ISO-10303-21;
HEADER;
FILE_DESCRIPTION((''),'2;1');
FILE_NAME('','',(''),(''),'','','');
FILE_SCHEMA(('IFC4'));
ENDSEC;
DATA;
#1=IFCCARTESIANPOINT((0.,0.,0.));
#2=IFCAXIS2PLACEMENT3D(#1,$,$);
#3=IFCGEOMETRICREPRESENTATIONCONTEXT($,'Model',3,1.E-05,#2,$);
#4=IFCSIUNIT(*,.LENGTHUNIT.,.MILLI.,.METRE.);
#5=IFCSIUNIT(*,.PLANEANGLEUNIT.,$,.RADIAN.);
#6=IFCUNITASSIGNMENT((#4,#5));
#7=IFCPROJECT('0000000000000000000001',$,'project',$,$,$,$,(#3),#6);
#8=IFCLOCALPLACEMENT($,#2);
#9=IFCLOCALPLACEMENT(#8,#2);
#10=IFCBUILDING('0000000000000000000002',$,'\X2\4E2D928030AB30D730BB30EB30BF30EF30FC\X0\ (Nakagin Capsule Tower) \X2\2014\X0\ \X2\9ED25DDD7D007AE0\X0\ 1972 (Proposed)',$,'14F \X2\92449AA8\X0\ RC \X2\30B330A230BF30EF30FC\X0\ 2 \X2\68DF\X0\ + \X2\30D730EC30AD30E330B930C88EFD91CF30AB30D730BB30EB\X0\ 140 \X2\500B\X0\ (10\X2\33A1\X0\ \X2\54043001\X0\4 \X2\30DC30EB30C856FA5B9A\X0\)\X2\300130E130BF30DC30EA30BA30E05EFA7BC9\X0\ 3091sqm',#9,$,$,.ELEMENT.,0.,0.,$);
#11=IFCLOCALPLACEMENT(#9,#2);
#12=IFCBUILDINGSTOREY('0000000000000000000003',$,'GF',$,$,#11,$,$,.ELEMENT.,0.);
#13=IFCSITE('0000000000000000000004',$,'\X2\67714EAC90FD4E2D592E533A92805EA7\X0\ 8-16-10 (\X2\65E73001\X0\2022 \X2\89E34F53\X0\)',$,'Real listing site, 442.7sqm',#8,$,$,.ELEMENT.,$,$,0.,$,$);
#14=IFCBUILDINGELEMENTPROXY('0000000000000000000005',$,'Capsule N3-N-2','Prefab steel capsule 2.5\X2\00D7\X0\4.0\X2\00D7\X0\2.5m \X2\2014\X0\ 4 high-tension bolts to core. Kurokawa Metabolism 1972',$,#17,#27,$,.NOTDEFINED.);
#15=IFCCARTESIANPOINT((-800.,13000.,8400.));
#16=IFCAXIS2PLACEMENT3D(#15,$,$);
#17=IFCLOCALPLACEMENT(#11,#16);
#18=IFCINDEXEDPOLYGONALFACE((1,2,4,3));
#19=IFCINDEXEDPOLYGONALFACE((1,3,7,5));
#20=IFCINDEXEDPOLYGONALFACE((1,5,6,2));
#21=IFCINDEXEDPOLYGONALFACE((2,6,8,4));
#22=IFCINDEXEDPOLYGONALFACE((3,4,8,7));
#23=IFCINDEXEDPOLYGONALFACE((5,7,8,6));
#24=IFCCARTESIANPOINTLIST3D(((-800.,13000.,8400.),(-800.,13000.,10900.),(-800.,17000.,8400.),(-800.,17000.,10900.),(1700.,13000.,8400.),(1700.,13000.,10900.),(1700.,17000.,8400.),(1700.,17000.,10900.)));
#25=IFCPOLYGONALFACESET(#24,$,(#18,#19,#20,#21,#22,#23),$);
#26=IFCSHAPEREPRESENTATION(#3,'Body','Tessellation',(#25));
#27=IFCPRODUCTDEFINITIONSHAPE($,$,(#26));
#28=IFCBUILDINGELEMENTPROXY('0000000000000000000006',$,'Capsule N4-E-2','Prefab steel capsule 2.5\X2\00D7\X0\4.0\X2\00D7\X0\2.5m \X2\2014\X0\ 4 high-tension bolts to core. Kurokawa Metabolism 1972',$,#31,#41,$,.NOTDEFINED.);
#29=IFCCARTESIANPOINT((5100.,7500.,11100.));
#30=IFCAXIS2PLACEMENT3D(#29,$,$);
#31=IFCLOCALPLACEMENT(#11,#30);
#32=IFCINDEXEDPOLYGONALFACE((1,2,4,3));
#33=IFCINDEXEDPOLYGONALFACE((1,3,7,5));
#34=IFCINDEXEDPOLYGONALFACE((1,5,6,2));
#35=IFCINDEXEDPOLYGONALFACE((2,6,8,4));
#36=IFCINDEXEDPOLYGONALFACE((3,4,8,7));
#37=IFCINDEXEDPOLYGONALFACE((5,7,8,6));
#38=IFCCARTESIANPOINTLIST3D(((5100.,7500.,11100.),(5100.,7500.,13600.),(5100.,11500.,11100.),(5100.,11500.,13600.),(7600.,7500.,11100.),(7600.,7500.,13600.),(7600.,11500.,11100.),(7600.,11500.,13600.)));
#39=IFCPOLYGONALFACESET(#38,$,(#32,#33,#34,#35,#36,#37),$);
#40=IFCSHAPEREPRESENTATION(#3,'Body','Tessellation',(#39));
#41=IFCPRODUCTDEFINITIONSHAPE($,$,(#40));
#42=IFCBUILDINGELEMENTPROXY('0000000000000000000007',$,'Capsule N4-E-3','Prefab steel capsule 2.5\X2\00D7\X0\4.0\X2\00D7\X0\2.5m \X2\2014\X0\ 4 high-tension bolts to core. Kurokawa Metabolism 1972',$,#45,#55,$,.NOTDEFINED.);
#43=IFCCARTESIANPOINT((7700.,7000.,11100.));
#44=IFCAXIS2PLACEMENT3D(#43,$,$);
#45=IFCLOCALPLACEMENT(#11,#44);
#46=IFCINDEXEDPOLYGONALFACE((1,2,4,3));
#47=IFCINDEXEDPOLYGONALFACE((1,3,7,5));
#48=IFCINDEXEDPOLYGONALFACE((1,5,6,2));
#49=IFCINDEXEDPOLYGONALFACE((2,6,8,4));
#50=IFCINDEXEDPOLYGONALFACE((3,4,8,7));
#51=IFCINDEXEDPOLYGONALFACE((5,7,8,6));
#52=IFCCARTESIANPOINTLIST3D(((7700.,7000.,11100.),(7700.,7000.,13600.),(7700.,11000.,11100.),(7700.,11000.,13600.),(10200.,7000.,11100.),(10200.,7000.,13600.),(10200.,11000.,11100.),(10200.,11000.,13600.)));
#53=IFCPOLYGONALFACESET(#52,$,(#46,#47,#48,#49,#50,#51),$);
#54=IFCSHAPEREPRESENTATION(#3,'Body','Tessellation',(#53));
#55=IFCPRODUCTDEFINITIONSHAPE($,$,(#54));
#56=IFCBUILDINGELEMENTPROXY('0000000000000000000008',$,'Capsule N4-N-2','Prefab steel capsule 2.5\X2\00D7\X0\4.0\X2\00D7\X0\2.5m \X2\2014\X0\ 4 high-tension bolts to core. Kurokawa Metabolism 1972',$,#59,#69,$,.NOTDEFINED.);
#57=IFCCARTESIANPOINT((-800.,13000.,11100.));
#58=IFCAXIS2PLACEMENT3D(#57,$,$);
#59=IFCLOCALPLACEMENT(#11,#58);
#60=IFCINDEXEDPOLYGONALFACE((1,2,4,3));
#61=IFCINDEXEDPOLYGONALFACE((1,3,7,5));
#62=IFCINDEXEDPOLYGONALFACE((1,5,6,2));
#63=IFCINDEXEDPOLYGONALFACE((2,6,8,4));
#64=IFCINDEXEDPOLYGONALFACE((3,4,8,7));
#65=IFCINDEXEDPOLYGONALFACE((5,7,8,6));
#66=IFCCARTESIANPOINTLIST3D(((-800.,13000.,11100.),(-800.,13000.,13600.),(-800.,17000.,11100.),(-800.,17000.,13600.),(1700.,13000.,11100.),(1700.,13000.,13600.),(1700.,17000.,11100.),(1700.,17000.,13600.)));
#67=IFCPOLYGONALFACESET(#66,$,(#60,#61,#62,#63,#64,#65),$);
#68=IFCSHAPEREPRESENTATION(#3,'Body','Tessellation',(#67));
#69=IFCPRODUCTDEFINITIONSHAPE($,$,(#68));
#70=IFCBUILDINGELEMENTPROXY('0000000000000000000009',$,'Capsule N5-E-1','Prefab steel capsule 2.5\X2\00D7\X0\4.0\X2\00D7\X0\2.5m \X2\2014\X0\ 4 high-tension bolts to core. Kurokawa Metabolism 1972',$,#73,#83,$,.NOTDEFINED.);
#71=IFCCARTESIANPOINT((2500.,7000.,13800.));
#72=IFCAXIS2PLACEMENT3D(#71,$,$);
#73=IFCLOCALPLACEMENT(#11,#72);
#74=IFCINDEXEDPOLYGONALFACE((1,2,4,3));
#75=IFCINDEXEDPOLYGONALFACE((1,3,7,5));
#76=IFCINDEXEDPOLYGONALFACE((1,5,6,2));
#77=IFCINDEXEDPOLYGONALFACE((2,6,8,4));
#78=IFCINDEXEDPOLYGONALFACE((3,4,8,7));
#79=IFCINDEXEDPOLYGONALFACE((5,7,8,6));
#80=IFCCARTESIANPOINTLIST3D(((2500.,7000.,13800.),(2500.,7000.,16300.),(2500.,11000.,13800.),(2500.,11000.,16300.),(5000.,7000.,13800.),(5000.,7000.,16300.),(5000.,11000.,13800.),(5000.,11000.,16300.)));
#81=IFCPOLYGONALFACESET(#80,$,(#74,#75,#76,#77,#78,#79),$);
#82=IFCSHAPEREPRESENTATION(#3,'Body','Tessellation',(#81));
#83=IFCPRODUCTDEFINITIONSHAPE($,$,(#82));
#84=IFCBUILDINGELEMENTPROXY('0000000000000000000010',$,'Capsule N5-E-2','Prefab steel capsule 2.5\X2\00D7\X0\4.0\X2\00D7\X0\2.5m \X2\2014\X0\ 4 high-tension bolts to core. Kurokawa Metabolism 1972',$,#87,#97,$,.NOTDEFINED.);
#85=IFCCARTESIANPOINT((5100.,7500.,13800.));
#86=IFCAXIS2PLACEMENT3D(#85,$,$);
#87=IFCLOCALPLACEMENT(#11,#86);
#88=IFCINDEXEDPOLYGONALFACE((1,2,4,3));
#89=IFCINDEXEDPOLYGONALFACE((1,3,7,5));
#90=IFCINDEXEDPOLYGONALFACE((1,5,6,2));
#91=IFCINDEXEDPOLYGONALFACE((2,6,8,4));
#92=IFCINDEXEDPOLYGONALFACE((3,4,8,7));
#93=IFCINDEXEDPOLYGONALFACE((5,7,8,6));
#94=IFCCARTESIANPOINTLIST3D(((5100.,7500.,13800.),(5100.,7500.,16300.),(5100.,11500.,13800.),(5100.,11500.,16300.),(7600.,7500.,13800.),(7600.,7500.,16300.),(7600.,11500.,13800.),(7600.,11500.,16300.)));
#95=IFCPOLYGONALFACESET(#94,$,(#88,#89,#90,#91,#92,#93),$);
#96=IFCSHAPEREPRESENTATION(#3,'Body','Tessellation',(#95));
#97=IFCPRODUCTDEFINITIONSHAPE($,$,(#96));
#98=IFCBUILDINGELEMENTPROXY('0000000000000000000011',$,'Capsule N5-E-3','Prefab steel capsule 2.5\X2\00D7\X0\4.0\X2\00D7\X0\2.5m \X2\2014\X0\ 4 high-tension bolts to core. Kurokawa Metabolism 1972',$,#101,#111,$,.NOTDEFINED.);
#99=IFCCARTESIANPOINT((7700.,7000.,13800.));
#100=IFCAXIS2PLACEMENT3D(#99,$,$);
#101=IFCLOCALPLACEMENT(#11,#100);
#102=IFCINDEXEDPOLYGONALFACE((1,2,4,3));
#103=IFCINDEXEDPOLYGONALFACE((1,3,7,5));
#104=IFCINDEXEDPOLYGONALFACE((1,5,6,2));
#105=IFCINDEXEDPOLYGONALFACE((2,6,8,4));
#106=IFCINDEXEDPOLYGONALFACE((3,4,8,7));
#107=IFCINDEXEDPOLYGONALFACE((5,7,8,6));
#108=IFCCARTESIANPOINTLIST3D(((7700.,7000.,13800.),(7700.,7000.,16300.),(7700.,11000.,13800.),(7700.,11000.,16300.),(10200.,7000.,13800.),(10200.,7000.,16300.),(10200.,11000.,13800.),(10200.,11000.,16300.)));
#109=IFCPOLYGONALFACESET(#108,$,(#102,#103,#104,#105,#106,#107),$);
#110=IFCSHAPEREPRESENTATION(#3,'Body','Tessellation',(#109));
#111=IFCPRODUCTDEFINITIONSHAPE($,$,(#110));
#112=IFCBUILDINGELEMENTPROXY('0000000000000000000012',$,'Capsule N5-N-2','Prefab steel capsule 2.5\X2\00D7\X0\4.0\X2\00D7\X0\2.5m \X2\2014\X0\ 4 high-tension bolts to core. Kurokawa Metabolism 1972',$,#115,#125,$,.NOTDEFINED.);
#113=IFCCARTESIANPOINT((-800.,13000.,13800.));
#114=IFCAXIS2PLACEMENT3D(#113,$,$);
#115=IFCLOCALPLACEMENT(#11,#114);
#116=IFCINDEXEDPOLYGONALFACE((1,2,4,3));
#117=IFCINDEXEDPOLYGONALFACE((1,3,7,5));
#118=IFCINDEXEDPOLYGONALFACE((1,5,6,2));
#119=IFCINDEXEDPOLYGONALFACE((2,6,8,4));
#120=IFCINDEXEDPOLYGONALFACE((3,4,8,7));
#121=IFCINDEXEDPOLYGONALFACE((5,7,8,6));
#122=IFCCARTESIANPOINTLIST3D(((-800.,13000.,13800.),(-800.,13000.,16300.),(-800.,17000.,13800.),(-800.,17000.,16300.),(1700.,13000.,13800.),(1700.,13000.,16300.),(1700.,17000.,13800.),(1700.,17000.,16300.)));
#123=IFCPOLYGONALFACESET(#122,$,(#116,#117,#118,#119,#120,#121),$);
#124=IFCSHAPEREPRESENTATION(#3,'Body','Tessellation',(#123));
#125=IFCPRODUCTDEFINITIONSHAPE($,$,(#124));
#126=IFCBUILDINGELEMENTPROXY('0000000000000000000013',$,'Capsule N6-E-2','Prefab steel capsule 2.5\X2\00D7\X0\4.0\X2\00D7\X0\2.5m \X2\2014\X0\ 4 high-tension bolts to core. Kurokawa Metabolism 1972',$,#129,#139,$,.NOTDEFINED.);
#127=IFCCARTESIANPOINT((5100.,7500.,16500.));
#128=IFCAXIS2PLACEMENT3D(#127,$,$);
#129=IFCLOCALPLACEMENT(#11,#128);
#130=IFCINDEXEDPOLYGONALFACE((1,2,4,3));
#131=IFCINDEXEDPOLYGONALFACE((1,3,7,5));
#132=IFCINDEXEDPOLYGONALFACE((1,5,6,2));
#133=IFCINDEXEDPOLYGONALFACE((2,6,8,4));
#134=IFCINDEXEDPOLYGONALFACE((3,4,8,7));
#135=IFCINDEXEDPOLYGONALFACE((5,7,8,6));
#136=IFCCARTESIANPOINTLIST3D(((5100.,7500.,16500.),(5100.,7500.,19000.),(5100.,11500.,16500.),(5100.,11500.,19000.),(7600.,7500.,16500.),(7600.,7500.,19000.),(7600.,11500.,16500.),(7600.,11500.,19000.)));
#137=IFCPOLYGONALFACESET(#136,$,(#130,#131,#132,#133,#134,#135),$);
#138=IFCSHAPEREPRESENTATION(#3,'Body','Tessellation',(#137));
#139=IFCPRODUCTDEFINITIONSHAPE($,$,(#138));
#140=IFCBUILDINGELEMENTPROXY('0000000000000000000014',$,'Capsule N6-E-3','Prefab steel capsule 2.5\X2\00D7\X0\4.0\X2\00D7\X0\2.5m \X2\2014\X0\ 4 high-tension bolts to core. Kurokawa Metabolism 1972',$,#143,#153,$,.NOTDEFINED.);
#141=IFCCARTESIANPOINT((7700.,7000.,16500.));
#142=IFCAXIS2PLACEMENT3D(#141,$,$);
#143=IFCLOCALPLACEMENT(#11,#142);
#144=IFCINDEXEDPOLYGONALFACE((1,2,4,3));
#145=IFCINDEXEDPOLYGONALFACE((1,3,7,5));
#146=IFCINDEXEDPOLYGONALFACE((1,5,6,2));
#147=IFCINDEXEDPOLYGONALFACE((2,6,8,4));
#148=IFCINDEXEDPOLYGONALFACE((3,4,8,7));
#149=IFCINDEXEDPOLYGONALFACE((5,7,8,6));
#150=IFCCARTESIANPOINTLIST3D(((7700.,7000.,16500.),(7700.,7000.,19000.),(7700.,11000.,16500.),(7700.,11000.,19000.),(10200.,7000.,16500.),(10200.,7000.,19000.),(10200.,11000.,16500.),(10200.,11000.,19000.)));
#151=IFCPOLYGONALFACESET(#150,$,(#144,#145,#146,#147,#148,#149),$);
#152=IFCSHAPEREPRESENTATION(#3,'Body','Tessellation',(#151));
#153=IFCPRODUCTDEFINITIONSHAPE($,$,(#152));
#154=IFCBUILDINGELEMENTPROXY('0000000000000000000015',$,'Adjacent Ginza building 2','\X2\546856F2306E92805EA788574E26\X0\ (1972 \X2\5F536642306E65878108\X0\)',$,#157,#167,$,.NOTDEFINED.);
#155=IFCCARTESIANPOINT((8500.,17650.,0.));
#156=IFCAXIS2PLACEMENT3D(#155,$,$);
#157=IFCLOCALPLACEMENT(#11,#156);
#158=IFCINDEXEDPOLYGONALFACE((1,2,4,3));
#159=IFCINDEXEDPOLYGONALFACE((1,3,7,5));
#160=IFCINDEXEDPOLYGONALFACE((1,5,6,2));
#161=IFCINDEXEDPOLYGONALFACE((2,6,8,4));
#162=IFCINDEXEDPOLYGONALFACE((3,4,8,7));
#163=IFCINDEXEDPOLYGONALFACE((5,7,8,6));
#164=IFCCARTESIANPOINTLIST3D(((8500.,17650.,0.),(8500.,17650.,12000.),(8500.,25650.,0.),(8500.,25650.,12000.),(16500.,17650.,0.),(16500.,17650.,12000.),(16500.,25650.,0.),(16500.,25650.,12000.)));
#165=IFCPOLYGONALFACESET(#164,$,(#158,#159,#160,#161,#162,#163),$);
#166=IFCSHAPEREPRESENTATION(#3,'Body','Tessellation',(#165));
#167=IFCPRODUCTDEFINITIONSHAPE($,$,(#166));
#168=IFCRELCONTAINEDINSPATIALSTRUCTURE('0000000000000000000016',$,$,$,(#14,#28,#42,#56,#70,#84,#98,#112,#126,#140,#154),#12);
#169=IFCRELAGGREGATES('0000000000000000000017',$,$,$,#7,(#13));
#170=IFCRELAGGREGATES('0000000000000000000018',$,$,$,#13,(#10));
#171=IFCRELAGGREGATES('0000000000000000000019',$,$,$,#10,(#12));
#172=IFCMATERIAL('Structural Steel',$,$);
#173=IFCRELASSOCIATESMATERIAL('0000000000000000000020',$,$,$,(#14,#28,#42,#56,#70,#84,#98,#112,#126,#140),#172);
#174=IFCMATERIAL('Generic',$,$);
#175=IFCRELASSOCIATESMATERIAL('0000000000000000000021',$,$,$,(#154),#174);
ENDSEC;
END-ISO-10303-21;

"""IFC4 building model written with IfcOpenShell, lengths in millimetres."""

from ifc_helpers import new_model, si_unit, frame, frame_2d, origin, place, context, project, spatial, rectangle, extrude, material, element, save


model = new_model("IFC4")

# Units and contexts
model_context = context("Model", 3, precision=1e-05, world=origin())
ifc_project = project(units=[si_unit("LENGTHUNIT", "METRE", prefix="MILLI"), si_unit("PLANEANGLEUNIT", "RADIAN")], contexts=[model_context])

# Site, building, storey
site_placement = place(None, origin())
site = spatial("IfcSite", under=ifc_project, at=site_placement, Name="東京都中央区銀座 8-16-10 (旧、2022 解体)", ObjectType="Real listing site, 442.7sqm", CompositionType="ELEMENT", RefElevation=0.0)
building_placement = place(site_placement, origin())
building = spatial("IfcBuilding", under=site, at=building_placement, Name="中銀カプセルタワー (Nakagin Capsule Tower) — 黒川紀章 1972 (Proposed)", ObjectType="14F 鉄骨 RC コアタワー 2 棟 + プレキャスト軽量カプセル 140 個 (10㎡ 各、4 ボルト固定)、メタボリズム建築 3091sqm", CompositionType="ELEMENT", ElevationOfRefHeight=0.0, ElevationOfTerrain=0.0)
storey_placement = place(building_placement, origin())
storey = spatial("IfcBuildingStorey", under=building, at=storey_placement, Name="GF", CompositionType="ELEMENT", Elevation=0.0)

# Shared definitions
ifc_material_1 = material(Name="Structural Steel")

# Building element proxies
proxy_1_placement = place(storey_placement, frame((-800.0, 13000.0, 8400.0)))
element("IfcBuildingElementProxy", 1, at=proxy_1_placement, inside=storey, material=ifc_material_1, Name="Capsule N3-N-2", Description="Prefab steel capsule 2.5×4.0×2.5m — 4 high-tension bolts to core. Kurokawa Metabolism 1972", PredefinedType="NOTDEFINED", context=model_context, shape_type="SweptSolid", body=[
    extrude(rectangle(XDim=2500.0, YDim=4000.0, at=frame_2d((1250.0, 2000.0))), frame((-800.0, 13000.0, 8400.0)), (0.0, 0.0, 1.0), 2500.0),
])
proxy_2_placement = place(storey_placement, frame((5100.0, 7500.0, 11100.0)))
element("IfcBuildingElementProxy", 2, at=proxy_2_placement, inside=storey, material=ifc_material_1, Name="Capsule N4-E-2", Description="Prefab steel capsule 2.5×4.0×2.5m — 4 high-tension bolts to core. Kurokawa Metabolism 1972", PredefinedType="NOTDEFINED", context=model_context, shape_type="SweptSolid", body=[
    extrude(rectangle(XDim=2500.0, YDim=4000.0, at=frame_2d((1250.0, 2000.0))), frame((5100.0, 7500.0, 11100.0)), (0.0, 0.0, 1.0), 2500.0),
])
proxy_3_placement = place(storey_placement, frame((7700.0, 7000.0, 11100.0)))
element("IfcBuildingElementProxy", 3, at=proxy_3_placement, inside=storey, material=ifc_material_1, Name="Capsule N4-E-3", Description="Prefab steel capsule 2.5×4.0×2.5m — 4 high-tension bolts to core. Kurokawa Metabolism 1972", PredefinedType="NOTDEFINED", context=model_context, shape_type="SweptSolid", body=[
    extrude(rectangle(XDim=2500.0, YDim=4000.0, at=frame_2d((1250.0, 2000.0))), frame((7700.0, 7000.0, 11100.0)), (0.0, 0.0, 1.0), 2500.0),
])
proxy_4_placement = place(storey_placement, frame((-800.0, 13000.0, 11100.0)))
element("IfcBuildingElementProxy", 4, at=proxy_4_placement, inside=storey, material=ifc_material_1, Name="Capsule N4-N-2", Description="Prefab steel capsule 2.5×4.0×2.5m — 4 high-tension bolts to core. Kurokawa Metabolism 1972", PredefinedType="NOTDEFINED", context=model_context, shape_type="SweptSolid", body=[
    extrude(rectangle(XDim=2500.0, YDim=4000.0, at=frame_2d((1250.0, 2000.0))), frame((-800.0, 13000.0, 11100.0)), (0.0, 0.0, 1.0), 2500.0),
])
proxy_5_placement = place(storey_placement, frame((2500.0, 7000.0, 13800.0)))
element("IfcBuildingElementProxy", 5, at=proxy_5_placement, inside=storey, material=ifc_material_1, Name="Capsule N5-E-1", Description="Prefab steel capsule 2.5×4.0×2.5m — 4 high-tension bolts to core. Kurokawa Metabolism 1972", PredefinedType="NOTDEFINED", context=model_context, shape_type="SweptSolid", body=[
    extrude(rectangle(XDim=2500.0, YDim=4000.0, at=frame_2d((1250.0, 2000.0))), frame((2500.0, 7000.0, 13800.0)), (0.0, 0.0, 1.0), 2500.0),
])
proxy_6_placement = place(storey_placement, frame((5100.0, 7500.0, 13800.0)))
element("IfcBuildingElementProxy", 6, at=proxy_6_placement, inside=storey, material=ifc_material_1, Name="Capsule N5-E-2", Description="Prefab steel capsule 2.5×4.0×2.5m — 4 high-tension bolts to core. Kurokawa Metabolism 1972", PredefinedType="NOTDEFINED", context=model_context, shape_type="SweptSolid", body=[
    extrude(rectangle(XDim=2500.0, YDim=4000.0, at=frame_2d((1250.0, 2000.0))), frame((5100.0, 7500.0, 13800.0)), (0.0, 0.0, 1.0), 2500.0),
])
proxy_7_placement = place(storey_placement, frame((7700.0, 7000.0, 13800.0)))
element("IfcBuildingElementProxy", 7, at=proxy_7_placement, inside=storey, material=ifc_material_1, Name="Capsule N5-E-3", Description="Prefab steel capsule 2.5×4.0×2.5m — 4 high-tension bolts to core. Kurokawa Metabolism 1972", PredefinedType="NOTDEFINED", context=model_context, shape_type="SweptSolid", body=[
    extrude(rectangle(XDim=2500.0, YDim=4000.0, at=frame_2d((1250.0, 2000.0))), frame((7700.0, 7000.0, 13800.0)), (0.0, 0.0, 1.0), 2500.0),
])
proxy_8_placement = place(storey_placement, frame((-800.0, 13000.0, 13800.0)))
element("IfcBuildingElementProxy", 8, at=proxy_8_placement, inside=storey, material=ifc_material_1, Name="Capsule N5-N-2", Description="Prefab steel capsule 2.5×4.0×2.5m — 4 high-tension bolts to core. Kurokawa Metabolism 1972", PredefinedType="NOTDEFINED", context=model_context, shape_type="SweptSolid", body=[
    extrude(rectangle(XDim=2500.0, YDim=4000.0, at=frame_2d((1250.0, 2000.0))), frame((-800.0, 13000.0, 13800.0)), (0.0, 0.0, 1.0), 2500.0),
])
proxy_9_placement = place(storey_placement, frame((5100.0, 7500.0, 16500.0)))
element("IfcBuildingElementProxy", 9, at=proxy_9_placement, inside=storey, material=ifc_material_1, Name="Capsule N6-E-2", Description="Prefab steel capsule 2.5×4.0×2.5m — 4 high-tension bolts to core. Kurokawa Metabolism 1972", PredefinedType="NOTDEFINED", context=model_context, shape_type="SweptSolid", body=[
    extrude(rectangle(XDim=2500.0, YDim=4000.0, at=frame_2d((1250.0, 2000.0))), frame((5100.0, 7500.0, 16500.0)), (0.0, 0.0, 1.0), 2500.0),
])
proxy_10_placement = place(storey_placement, frame((7700.0, 7000.0, 16500.0)))
element("IfcBuildingElementProxy", 10, at=proxy_10_placement, inside=storey, material=ifc_material_1, Name="Capsule N6-E-3", Description="Prefab steel capsule 2.5×4.0×2.5m — 4 high-tension bolts to core. Kurokawa Metabolism 1972", PredefinedType="NOTDEFINED", context=model_context, shape_type="SweptSolid", body=[
    extrude(rectangle(XDim=2500.0, YDim=4000.0, at=frame_2d((1250.0, 2000.0))), frame((7700.0, 7000.0, 16500.0)), (0.0, 0.0, 1.0), 2500.0),
])
ifc_material_2 = material(Name="Generic")
proxy_11_placement = place(storey_placement, frame((8500.0, 17650.0, 0.0)))
element("IfcBuildingElementProxy", 11, at=proxy_11_placement, inside=storey, material=ifc_material_2, Name="Adjacent Ginza building 2", Description="周囲の銀座街並 (1972 当時の文脈)", PredefinedType="NOTDEFINED", context=model_context, shape_type="SweptSolid", body=[
    extrude(rectangle(XDim=8000.0, YDim=8000.0, at=frame_2d((4000.0, 4000.0))), frame((8500.0, 17650.0, 0.0)), (0.0, 0.0, 1.0), 12000.0),
])

save(model, "model.ifc")
